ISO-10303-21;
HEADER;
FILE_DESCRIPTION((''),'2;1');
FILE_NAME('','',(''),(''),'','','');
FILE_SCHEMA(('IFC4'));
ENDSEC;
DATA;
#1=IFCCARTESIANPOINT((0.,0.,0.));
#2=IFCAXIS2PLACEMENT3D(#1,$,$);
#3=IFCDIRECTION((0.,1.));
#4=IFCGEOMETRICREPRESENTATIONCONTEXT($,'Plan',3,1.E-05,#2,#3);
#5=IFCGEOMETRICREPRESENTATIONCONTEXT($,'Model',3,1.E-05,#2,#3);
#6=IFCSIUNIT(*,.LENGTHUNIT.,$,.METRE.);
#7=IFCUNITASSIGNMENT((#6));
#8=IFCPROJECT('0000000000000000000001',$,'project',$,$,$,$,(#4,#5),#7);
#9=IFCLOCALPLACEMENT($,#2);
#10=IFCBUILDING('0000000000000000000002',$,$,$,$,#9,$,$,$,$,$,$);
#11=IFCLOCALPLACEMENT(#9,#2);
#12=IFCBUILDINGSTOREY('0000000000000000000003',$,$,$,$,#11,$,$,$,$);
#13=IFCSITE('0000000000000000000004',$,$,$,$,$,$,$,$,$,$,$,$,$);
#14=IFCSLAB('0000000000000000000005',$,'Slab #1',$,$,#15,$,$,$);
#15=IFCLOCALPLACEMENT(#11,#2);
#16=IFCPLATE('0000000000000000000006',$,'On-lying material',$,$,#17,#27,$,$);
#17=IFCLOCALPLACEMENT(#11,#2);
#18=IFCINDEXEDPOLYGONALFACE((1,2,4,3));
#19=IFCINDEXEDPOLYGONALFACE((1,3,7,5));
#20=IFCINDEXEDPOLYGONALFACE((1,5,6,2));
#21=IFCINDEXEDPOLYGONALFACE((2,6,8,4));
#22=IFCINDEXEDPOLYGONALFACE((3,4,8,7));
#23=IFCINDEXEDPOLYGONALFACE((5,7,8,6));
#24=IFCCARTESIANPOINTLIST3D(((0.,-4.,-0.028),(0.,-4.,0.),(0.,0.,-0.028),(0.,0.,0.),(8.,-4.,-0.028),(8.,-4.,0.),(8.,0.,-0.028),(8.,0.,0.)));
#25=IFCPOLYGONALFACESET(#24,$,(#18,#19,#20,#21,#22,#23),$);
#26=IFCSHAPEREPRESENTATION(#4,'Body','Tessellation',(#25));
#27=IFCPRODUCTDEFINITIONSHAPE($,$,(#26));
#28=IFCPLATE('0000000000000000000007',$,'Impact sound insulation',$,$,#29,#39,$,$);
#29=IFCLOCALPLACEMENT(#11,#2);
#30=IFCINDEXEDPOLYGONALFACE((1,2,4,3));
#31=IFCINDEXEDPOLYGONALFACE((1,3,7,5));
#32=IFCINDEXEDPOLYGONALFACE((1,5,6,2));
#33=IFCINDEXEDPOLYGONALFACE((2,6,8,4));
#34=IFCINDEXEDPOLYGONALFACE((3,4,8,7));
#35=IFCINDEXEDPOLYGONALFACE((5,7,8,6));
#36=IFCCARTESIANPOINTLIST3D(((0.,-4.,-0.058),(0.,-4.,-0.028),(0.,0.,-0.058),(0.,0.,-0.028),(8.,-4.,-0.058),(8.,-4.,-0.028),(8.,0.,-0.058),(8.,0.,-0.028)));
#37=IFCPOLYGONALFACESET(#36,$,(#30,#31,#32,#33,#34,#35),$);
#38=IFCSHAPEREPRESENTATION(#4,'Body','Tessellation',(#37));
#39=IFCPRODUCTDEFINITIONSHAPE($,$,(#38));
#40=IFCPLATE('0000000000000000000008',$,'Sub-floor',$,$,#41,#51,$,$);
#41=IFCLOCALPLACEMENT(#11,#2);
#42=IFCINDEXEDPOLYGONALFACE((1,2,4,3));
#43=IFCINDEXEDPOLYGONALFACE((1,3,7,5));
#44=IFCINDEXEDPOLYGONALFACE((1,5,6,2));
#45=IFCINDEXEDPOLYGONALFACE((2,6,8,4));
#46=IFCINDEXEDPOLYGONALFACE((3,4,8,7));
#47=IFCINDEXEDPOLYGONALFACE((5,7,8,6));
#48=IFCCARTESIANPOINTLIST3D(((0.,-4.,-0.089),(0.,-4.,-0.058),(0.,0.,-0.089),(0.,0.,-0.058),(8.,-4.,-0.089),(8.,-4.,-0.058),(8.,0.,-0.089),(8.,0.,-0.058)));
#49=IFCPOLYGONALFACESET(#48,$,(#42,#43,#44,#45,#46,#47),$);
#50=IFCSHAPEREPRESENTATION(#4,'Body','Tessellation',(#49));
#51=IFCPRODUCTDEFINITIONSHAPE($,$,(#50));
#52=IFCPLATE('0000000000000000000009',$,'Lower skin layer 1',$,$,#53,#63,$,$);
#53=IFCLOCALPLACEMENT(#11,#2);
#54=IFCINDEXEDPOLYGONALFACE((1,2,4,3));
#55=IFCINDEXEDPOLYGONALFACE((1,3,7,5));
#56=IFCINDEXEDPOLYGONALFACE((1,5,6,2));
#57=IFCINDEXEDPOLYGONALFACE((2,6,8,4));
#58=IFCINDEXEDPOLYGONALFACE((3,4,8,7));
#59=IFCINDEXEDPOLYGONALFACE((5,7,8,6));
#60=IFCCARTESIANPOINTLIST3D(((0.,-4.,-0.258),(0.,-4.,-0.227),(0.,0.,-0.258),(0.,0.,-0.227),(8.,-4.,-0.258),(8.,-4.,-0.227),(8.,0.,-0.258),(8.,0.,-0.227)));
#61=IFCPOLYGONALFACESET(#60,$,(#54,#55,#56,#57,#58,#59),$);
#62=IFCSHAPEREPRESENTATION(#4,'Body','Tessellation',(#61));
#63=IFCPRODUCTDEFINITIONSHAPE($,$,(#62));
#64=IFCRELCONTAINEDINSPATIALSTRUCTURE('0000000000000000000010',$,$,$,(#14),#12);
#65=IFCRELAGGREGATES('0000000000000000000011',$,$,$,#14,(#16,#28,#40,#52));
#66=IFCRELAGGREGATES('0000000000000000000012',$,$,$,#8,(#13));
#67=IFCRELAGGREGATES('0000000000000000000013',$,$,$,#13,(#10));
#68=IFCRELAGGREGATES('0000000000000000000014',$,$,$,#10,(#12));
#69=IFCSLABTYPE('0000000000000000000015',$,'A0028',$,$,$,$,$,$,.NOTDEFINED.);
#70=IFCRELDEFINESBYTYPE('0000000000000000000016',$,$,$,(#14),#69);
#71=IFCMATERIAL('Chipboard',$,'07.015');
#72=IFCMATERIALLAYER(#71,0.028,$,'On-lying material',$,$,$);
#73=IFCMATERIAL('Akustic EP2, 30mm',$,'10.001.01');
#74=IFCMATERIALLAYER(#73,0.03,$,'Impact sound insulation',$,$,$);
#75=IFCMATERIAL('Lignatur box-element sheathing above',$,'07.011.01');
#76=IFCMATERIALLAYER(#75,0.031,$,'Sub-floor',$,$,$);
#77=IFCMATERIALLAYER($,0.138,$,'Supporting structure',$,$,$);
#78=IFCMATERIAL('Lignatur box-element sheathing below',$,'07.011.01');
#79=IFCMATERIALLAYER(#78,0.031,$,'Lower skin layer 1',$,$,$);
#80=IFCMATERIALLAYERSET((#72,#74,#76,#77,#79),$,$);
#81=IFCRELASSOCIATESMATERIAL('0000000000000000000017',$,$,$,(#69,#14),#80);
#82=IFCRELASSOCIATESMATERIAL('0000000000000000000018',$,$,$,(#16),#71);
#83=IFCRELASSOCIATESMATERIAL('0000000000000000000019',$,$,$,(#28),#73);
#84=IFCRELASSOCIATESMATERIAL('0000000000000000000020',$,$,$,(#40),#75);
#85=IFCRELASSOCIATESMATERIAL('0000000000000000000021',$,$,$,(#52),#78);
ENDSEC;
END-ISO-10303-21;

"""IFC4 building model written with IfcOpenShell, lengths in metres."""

from ifc_helpers import new_model, si_unit, direction, frame, frame_2d, origin, origin_with_axes, place, context, project, spatial, rectangle, extrude, material, layer, layer_set, type_object, element, aggregate, save


model = new_model("IFC4")

# Units and contexts
plan_context = context("Plan", 3, precision=1e-05, world=origin(), true_north=direction((0.0, 1.0)))
model_context = context("Model", 3, precision=1e-05, world=origin(), true_north=direction((0.0, 1.0)))
ifc_project = project(units=[si_unit("LENGTHUNIT", "METRE")], contexts=[plan_context, model_context])

# Site, building, storey
site = spatial("IfcSite", under=ifc_project)
building_placement = place(None, origin())
building = spatial("IfcBuilding", under=site, at=building_placement)
storey_placement = place(building_placement, origin())
storey = spatial("IfcBuildingStorey", under=building, at=storey_placement)

# Slab, plates
ifc_material_1 = material(Name="Chipboard", Category="07.015")
ifc_layer_1 = layer(ifc_material_1, 0.028, Name="On-lying material")
ifc_material_2 = material(Name="Akustic EP2, 30mm", Category="10.001.01")
ifc_layer_2 = layer(ifc_material_2, 0.03, Name="Impact sound insulation")
ifc_material_3 = material(Name="Lignatur box-element sheathing above", Category="07.011.01")
ifc_layer_3 = layer(ifc_material_3, 0.031, Name="Sub-floor")
ifc_layer_4 = layer(None, 0.138, Name="Supporting structure")
ifc_material_4 = material(Name="Lignatur box-element sheathing below", Category="07.011.01")
ifc_layer_5 = layer(ifc_material_4, 0.031, Name="Lower skin layer 1")
ifc_layer_set = layer_set([ifc_layer_1, ifc_layer_2, ifc_layer_3, ifc_layer_4, ifc_layer_5])
slab_type = type_object("IfcSlabType", Name="A0028", PredefinedType="NOTDEFINED", material=ifc_layer_set)
slab_placement = place(None, frame((0.0, 0.0, 0.0), z_axis=(0.0, 0.0, -1.0), x_axis=(1.0, 0.0, 0.0)))
slab = element("IfcSlab", 1, at=slab_placement, inside=storey, type_object=slab_type, material=ifc_layer_set, Name="Slab #1")
plate_1_placement = place(slab_placement, origin())
plate_1 = element("IfcPlate", 2, at=plate_1_placement, material=ifc_material_1, Name="On-lying material", context=plan_context, shape_type="SweptSolid", body=[
    extrude(rectangle(XDim=8.0, YDim=4.0, at=frame_2d((4.0, 2.0), x_axis=(1.0, 0.0))), origin_with_axes(), (0.0, 0.0, 1.0), 0.028),
])
plate_2_placement = place(slab_placement, origin())
plate_2 = element("IfcPlate", 3, at=plate_2_placement, material=ifc_material_2, Name="Impact sound insulation", context=plan_context, shape_type="SweptSolid", body=[
    extrude(rectangle(XDim=8.0, YDim=4.0, at=frame_2d((4.0, 2.0), x_axis=(1.0, 0.0))), frame((0.0, 0.0, 0.028), z_axis=(0.0, 0.0, 1.0), x_axis=(1.0, 0.0, 0.0)), (0.0, 0.0, 1.0), 0.03),
])
plate_3_placement = place(slab_placement, origin())
plate_3 = element("IfcPlate", 4, at=plate_3_placement, material=ifc_material_3, Name="Sub-floor", context=plan_context, shape_type="SweptSolid", body=[
    extrude(rectangle(XDim=8.0, YDim=4.0, at=frame_2d((4.0, 2.0), x_axis=(1.0, 0.0))), frame((0.0, 0.0, 0.058), z_axis=(0.0, 0.0, 1.0), x_axis=(1.0, 0.0, 0.0)), (0.0, 0.0, 1.0), 0.031),
])
plate_4_placement = place(slab_placement, origin())
plate_4 = element("IfcPlate", 5, at=plate_4_placement, material=ifc_material_4, Name="Lower skin layer 1", context=plan_context, shape_type="SweptSolid", body=[
    extrude(rectangle(XDim=8.0, YDim=4.0, at=frame_2d((4.0, 2.0), x_axis=(1.0, 0.0))), frame((0.0, 0.0, 0.227), z_axis=(0.0, 0.0, 1.0), x_axis=(1.0, 0.0, 0.0)), (0.0, 0.0, 1.0), 0.031),
])
aggregate(slab, [plate_1, plate_2, plate_3, plate_4])

save(model, "model.ifc")
